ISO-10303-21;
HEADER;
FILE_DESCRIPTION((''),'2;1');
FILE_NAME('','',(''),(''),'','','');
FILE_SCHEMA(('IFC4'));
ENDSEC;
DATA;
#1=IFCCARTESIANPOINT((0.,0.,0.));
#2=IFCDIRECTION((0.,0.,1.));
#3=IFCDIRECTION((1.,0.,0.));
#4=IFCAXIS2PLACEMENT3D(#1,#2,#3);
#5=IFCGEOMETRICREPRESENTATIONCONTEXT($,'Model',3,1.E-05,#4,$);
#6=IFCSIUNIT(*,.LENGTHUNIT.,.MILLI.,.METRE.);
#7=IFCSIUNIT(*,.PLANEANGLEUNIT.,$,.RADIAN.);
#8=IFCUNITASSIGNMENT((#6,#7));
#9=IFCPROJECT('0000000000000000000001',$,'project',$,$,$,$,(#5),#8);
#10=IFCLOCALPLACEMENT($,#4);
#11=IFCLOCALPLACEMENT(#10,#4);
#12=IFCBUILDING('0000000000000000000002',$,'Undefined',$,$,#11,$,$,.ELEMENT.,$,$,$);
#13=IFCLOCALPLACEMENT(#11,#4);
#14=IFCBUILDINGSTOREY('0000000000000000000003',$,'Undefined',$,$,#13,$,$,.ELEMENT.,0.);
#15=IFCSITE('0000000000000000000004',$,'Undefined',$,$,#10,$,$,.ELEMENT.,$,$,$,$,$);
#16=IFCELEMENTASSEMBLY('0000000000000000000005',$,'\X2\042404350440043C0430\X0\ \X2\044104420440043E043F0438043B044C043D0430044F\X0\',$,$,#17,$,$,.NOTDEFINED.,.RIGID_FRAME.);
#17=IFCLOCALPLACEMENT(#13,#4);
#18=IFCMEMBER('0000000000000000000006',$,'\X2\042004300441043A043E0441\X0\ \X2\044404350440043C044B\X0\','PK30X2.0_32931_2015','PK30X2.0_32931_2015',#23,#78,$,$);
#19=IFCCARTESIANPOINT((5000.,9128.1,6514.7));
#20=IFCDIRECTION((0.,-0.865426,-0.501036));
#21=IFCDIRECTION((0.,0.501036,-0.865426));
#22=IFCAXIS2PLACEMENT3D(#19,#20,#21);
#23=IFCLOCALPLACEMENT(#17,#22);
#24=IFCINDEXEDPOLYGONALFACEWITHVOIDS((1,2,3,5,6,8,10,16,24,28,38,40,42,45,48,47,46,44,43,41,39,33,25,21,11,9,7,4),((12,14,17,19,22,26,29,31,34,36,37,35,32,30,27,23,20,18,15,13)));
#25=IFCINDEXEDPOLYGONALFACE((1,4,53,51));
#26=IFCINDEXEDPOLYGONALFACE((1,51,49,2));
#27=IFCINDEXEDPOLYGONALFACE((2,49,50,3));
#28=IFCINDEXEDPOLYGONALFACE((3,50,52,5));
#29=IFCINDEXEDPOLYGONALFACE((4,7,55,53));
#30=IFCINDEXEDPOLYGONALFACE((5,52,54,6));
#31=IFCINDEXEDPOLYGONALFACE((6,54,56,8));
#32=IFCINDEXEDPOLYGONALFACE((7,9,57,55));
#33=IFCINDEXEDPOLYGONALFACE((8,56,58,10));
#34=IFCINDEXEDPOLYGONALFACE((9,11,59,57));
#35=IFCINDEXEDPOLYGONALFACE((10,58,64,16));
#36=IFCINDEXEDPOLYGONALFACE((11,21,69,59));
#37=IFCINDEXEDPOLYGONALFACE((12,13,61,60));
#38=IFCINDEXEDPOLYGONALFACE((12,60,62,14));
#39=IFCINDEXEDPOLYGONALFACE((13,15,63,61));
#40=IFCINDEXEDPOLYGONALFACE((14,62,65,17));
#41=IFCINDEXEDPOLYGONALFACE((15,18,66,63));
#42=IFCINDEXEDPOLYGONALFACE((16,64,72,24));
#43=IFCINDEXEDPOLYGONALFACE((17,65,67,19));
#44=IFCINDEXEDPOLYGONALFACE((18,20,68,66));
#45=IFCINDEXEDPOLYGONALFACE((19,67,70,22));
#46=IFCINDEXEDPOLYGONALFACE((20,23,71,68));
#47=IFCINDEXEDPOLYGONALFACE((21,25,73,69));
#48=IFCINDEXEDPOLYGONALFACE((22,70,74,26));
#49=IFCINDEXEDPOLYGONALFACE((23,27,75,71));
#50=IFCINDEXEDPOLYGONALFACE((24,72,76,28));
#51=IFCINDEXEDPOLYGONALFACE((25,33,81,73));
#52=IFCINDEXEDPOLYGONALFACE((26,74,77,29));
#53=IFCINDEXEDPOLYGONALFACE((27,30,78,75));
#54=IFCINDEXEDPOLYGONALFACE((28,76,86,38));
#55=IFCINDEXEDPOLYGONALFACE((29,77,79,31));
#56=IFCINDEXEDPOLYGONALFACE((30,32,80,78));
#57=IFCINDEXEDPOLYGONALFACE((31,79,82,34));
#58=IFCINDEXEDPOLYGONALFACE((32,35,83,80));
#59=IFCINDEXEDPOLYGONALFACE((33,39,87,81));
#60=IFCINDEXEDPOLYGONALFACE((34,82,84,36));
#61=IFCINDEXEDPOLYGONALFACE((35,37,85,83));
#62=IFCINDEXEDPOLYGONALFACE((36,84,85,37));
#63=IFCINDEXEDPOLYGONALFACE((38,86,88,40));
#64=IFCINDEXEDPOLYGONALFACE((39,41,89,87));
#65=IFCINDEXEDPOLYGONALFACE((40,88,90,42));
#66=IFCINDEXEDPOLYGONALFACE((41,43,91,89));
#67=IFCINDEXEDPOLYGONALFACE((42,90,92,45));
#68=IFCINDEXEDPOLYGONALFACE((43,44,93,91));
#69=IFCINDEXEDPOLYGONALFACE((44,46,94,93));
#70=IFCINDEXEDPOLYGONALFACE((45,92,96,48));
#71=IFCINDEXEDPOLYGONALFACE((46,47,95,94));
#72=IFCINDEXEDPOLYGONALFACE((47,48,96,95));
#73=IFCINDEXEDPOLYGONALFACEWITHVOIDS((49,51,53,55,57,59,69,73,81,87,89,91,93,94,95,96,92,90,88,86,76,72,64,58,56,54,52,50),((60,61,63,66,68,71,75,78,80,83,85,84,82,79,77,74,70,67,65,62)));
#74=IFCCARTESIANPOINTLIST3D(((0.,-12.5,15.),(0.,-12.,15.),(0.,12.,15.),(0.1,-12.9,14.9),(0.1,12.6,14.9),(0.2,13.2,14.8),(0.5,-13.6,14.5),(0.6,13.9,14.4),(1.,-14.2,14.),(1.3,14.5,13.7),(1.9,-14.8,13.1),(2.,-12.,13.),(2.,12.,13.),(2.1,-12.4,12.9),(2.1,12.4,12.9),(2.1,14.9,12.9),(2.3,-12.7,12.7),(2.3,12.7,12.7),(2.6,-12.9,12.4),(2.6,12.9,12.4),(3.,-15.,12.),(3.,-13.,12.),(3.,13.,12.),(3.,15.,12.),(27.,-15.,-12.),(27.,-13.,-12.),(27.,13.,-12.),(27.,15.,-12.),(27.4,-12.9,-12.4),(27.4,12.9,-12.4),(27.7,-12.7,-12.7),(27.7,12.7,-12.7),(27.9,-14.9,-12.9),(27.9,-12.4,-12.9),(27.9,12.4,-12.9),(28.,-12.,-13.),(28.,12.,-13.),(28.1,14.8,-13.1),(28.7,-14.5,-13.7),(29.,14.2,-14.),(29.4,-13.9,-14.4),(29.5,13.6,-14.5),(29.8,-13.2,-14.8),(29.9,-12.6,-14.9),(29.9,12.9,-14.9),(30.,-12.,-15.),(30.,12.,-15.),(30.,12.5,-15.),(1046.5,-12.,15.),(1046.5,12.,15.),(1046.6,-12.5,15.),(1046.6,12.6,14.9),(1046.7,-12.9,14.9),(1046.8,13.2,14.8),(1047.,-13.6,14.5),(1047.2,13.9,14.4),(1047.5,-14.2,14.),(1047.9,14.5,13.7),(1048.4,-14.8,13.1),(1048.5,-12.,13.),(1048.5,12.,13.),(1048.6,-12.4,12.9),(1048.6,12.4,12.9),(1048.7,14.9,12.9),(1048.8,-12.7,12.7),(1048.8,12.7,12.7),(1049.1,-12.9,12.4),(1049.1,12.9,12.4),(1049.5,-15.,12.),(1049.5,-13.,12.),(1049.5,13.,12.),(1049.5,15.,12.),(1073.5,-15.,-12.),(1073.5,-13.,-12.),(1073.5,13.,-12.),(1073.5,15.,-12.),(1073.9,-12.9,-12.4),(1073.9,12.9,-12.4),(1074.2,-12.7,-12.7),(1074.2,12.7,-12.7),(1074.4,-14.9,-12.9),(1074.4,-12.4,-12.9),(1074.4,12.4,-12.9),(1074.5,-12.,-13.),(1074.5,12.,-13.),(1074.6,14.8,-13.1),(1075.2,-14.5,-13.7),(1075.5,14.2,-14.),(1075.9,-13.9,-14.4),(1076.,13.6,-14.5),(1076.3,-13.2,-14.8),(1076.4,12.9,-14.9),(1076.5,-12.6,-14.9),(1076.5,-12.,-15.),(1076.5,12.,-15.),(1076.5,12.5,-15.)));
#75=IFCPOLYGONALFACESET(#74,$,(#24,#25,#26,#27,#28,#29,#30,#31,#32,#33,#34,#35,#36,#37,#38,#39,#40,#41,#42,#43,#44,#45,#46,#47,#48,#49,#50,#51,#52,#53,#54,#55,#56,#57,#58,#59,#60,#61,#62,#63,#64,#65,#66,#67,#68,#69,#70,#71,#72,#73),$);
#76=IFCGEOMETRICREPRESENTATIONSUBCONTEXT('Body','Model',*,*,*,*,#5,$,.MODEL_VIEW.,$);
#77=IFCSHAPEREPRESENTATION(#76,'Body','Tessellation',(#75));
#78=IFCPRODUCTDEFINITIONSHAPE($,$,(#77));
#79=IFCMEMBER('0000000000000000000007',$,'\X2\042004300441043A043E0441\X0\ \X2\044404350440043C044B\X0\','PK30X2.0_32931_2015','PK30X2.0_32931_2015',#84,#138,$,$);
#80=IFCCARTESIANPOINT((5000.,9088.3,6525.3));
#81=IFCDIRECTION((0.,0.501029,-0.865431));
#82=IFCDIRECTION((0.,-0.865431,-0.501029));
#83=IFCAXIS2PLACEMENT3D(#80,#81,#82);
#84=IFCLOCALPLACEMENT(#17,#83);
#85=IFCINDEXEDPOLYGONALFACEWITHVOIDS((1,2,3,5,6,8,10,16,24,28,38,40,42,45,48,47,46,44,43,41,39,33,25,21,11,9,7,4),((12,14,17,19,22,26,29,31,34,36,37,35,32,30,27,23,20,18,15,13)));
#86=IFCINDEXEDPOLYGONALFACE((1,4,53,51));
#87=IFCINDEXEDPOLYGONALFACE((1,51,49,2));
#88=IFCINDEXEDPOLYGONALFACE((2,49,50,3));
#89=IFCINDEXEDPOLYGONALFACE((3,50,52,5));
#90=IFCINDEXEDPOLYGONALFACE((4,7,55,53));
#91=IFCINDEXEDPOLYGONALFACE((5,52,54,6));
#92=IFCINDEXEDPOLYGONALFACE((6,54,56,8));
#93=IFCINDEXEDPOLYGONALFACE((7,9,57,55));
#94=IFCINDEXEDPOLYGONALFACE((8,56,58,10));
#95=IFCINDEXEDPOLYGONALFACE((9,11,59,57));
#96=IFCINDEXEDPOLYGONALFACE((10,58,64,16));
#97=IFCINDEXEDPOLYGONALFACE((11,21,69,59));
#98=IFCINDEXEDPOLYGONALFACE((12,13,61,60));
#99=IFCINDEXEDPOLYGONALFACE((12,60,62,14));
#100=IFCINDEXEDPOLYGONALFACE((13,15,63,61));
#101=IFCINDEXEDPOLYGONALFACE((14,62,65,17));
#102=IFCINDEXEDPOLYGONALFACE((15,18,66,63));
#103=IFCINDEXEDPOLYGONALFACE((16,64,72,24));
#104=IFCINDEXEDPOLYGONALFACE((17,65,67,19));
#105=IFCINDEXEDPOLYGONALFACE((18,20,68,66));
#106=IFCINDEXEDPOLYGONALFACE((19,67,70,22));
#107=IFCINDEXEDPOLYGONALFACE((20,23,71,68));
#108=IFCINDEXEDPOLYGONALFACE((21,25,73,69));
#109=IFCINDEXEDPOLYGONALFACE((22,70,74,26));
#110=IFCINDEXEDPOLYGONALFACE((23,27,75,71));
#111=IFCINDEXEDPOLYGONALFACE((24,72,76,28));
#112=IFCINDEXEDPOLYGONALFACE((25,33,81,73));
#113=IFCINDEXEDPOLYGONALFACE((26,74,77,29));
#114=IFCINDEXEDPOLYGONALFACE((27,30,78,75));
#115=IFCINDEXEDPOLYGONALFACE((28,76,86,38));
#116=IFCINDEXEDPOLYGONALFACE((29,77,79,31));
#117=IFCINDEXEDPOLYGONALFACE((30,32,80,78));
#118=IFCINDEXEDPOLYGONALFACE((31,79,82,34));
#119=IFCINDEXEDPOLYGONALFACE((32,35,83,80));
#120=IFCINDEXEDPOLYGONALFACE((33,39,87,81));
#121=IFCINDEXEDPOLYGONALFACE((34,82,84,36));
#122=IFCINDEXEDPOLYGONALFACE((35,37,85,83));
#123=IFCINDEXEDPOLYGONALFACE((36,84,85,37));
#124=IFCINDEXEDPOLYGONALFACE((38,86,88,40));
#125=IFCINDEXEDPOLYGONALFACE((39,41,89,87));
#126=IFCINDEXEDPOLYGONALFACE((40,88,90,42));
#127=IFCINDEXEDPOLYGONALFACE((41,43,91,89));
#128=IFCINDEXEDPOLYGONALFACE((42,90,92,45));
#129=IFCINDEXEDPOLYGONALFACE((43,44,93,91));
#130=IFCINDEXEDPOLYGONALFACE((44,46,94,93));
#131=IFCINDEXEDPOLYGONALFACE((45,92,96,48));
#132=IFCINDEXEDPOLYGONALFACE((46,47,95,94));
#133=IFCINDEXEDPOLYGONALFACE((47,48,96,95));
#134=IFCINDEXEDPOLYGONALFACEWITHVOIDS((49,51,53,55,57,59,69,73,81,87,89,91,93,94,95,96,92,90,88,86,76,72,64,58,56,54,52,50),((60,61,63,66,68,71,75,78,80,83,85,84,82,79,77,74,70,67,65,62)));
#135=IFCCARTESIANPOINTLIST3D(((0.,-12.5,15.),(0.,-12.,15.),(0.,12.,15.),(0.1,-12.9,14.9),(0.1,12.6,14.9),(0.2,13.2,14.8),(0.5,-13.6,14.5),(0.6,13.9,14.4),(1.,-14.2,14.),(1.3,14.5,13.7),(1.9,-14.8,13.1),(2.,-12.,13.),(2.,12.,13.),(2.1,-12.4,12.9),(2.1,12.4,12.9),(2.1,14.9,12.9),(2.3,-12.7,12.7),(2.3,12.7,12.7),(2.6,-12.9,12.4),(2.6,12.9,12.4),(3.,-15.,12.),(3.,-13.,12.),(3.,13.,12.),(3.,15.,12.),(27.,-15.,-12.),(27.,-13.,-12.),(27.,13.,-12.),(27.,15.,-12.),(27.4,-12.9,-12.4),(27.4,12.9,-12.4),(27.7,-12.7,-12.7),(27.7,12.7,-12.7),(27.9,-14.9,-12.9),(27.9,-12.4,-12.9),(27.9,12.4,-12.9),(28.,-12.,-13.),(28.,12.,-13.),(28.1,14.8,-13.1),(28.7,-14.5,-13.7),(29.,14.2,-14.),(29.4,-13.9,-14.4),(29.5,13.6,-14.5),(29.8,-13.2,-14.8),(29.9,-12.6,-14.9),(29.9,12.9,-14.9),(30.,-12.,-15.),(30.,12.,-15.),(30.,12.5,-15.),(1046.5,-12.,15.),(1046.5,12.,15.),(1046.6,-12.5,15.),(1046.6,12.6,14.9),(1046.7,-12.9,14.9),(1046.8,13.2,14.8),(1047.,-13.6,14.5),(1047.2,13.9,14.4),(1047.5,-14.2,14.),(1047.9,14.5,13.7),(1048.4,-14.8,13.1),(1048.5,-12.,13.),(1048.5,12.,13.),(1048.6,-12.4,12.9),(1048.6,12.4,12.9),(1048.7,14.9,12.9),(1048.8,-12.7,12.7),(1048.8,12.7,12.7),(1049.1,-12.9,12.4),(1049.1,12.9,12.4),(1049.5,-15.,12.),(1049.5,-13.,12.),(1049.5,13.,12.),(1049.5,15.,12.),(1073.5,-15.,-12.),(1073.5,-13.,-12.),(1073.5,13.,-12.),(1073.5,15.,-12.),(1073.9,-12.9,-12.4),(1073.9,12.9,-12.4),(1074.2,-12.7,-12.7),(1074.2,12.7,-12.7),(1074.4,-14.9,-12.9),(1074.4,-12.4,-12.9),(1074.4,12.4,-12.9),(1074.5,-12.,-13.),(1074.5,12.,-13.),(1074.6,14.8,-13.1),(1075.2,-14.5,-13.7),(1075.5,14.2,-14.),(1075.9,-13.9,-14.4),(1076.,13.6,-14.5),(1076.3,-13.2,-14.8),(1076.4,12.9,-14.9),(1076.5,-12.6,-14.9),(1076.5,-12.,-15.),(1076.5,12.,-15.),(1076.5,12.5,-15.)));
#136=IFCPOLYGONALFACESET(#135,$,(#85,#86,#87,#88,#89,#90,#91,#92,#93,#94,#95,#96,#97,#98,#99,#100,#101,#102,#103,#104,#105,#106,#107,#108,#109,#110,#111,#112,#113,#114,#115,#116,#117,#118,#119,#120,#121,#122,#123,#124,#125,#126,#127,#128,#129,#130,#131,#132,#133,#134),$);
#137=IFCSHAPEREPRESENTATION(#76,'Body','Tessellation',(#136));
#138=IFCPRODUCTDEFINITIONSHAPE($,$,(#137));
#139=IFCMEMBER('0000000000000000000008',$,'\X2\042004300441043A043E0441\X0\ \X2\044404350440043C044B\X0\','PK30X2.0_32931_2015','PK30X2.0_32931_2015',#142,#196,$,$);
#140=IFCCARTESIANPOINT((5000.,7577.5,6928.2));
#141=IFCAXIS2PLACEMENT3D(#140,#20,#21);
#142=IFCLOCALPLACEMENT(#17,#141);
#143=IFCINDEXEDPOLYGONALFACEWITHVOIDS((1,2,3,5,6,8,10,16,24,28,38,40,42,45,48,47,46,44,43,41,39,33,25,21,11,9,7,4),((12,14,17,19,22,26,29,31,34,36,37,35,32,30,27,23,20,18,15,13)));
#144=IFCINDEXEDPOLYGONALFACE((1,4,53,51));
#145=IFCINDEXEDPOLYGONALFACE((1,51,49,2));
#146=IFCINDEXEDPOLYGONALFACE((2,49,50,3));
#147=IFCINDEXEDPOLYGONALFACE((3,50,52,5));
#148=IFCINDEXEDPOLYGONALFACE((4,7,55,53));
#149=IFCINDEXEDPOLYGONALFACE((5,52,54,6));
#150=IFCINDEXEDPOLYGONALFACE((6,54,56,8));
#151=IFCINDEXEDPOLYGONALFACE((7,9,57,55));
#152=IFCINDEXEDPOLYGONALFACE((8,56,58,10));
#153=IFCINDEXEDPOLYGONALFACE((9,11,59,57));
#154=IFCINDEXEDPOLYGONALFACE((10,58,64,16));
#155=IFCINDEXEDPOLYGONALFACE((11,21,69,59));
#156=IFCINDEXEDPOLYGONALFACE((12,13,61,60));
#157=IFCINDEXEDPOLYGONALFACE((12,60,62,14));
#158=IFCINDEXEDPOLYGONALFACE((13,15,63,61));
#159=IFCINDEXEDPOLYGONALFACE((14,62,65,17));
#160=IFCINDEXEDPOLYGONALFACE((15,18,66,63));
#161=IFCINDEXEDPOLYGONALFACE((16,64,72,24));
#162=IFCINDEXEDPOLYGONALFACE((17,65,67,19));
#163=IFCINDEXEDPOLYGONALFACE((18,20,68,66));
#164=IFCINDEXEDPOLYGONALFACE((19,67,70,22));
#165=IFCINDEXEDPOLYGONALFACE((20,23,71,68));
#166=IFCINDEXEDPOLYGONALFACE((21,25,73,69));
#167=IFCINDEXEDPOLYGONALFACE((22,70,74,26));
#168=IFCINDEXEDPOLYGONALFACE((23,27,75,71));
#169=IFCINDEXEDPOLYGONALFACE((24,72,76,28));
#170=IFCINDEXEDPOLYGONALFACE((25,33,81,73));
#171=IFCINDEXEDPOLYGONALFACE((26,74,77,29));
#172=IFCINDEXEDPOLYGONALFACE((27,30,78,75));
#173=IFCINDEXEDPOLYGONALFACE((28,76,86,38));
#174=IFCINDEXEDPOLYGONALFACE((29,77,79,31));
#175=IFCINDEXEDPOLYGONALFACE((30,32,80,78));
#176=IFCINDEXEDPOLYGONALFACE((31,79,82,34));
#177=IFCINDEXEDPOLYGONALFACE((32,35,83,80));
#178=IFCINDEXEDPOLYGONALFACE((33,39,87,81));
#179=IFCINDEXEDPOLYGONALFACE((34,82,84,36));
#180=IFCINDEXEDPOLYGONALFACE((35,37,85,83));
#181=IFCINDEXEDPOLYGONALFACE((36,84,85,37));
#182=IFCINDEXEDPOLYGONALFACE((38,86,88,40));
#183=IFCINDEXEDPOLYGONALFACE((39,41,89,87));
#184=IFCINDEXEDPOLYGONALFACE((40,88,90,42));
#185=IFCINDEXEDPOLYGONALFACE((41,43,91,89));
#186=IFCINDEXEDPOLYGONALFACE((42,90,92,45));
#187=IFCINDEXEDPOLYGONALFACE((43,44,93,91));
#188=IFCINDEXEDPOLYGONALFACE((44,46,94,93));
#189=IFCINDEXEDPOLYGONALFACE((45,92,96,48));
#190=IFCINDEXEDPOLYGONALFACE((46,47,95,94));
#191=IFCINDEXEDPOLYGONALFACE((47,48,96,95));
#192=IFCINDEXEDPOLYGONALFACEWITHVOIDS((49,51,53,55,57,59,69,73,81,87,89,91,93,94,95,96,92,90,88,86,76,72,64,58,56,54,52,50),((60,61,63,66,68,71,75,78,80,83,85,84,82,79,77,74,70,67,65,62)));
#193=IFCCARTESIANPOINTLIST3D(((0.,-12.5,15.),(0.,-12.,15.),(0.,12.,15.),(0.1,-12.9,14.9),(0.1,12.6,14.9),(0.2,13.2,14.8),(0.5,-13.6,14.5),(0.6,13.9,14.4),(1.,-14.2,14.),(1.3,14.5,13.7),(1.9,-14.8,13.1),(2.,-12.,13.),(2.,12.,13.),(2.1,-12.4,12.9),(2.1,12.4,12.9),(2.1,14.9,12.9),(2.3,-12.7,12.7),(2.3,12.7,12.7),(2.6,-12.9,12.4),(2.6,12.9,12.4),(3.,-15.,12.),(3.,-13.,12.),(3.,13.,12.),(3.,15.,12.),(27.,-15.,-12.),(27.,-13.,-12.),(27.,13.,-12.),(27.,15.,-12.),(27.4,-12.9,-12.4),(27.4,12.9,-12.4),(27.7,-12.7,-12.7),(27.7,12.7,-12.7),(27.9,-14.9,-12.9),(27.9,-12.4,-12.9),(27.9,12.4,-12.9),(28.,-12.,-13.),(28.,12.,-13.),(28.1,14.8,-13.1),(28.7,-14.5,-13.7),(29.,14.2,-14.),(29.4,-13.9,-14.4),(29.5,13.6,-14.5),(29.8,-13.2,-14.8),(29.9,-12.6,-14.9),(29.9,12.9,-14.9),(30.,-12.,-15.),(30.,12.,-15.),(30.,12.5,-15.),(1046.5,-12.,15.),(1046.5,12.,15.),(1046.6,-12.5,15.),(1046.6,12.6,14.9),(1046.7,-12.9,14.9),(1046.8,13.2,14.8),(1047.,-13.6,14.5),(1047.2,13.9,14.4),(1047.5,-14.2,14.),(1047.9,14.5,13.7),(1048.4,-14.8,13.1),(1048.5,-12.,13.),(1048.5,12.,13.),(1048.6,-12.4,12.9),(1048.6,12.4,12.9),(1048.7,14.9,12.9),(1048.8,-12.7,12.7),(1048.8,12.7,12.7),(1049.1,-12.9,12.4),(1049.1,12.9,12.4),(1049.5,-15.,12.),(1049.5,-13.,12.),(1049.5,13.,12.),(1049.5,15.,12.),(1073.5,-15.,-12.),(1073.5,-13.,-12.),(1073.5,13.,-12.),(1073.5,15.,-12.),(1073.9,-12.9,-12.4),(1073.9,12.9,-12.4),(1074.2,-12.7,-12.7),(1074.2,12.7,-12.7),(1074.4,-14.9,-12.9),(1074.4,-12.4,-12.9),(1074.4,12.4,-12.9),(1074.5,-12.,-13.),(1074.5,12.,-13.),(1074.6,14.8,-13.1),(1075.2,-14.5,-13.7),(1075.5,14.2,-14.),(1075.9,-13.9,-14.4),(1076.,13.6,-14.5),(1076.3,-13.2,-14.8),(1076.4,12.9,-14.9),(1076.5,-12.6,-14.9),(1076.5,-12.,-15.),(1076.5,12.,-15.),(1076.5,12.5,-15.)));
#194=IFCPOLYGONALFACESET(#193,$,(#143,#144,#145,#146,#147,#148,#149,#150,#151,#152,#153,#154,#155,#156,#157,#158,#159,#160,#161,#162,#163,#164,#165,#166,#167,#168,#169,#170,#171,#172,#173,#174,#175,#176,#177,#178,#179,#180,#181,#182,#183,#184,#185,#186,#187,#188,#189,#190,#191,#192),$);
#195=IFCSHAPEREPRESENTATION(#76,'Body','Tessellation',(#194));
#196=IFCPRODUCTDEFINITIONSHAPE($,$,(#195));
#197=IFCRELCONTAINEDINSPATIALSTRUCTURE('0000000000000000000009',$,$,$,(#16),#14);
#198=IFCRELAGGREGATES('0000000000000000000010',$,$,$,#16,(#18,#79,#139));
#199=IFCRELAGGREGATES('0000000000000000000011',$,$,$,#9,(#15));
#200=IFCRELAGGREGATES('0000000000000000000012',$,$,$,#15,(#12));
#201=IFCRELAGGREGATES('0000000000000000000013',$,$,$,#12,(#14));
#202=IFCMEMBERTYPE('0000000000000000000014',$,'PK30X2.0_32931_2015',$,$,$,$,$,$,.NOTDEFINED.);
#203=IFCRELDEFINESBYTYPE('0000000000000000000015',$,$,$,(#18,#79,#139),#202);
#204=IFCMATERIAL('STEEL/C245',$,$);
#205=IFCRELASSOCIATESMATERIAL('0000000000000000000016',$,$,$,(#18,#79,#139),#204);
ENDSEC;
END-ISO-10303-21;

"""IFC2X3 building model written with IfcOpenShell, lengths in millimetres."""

from ifc_helpers import new_model, si_unit, frame, origin_with_axes, origin_2d_with_axis, place, context, subcontext, project, spatial, hollow_rectangle, extrude, clip, halfspace, material, type_object, element, aggregate, save


model = new_model("IFC2X3")

# Units and contexts
model_context = context("Model", 3, precision=1e-05, world=origin_with_axes())
body_context = subcontext(model_context, "Body", "Model", "MODEL_VIEW")
ifc_project = project(units=[si_unit("LENGTHUNIT", "METRE", prefix="MILLI"), si_unit("PLANEANGLEUNIT", "RADIAN")], contexts=[model_context])

# Site, building, storey
site_placement = place(None, origin_with_axes())
site = spatial("IfcSite", under=ifc_project, at=site_placement, Name="Undefined", CompositionType="ELEMENT")
building_placement = place(site_placement, origin_with_axes())
building = spatial("IfcBuilding", under=site, at=building_placement, Name="Undefined", CompositionType="ELEMENT")
storey_placement = place(building_placement, origin_with_axes())
storey = spatial("IfcBuildingStorey", under=building, at=storey_placement, Name="Undefined", CompositionType="ELEMENT", Elevation=0.0)

# Element assembly
ifc_material_1 = material(Name="STEEL/C245")
assembly_1_placement = place(storey_placement, origin_with_axes())
assembly_1 = element("IfcElementAssembly", 1, at=assembly_1_placement, inside=storey, Name="Ферма стропильная", AssemblyPlace="NOTDEFINED", PredefinedType="RIGID_FRAME")

# Members
member_type = type_object("IfcMemberType", Name="PK30X2.0_32931_2015", PredefinedType="NOTDEFINED")
member_1_placement = place(assembly_1_placement, frame((5000.0, 9128.1, 6514.7), z_axis=(0.0, -0.865426, -0.501036), x_axis=(0.0, 0.501036, -0.865426)))
member_1 = element("IfcMember", 2, at=member_1_placement, type_object=member_type, material=ifc_material_1, Name="Раскос фермы", Description="PK30X2.0_32931_2015", ObjectType="PK30X2.0_32931_2015", context=body_context, shape_type="Clipping", body=[
    clip(clip(extrude(hollow_rectangle(XDim=30.0, YDim=30.0, WallThickness=2.0, InnerFilletRadius=1.0, OuterFilletRadius=3.0, at=origin_2d_with_axis()), frame((1091.8, 0.0, 0.0), z_axis=(-1.0, 0.0, 0.0), x_axis=(0.0, -1.0, 0.0)), (0.0, 0.0, 1.0), 1107.1), halfspace(frame((1060.0, 0.0, 1.5), z_axis=(-0.707107, 0.0, -0.707107), x_axis=(0.707107, 0.0, -0.707107)), True)), halfspace(frame((34.5, 0.0, -19.5), z_axis=(-0.707107, 0.0, -0.707107), x_axis=(0.707107, 0.0, -0.707107)), False)),
])
member_2_placement = place(assembly_1_placement, frame((5000.0, 9088.3, 6525.3), z_axis=(0.0, 0.501029, -0.865431), x_axis=(0.0, -0.865431, -0.501029)))
member_2 = element("IfcMember", 3, at=member_2_placement, type_object=member_type, material=ifc_material_1, Name="Раскос фермы", Description="PK30X2.0_32931_2015", ObjectType="PK30X2.0_32931_2015", context=body_context, shape_type="Clipping", body=[
    clip(clip(extrude(hollow_rectangle(XDim=30.0, YDim=30.0, WallThickness=2.0, InnerFilletRadius=1.0, OuterFilletRadius=3.0, at=origin_2d_with_axis()), frame((1102.9, 0.0, 0.0), z_axis=(-1.0, 0.0, 0.0), x_axis=(0.0, -1.0, 0.0)), (0.0, 0.0, 1.0), 1129.2), halfspace(frame((1060.0, 0.0, 1.5), z_axis=(-0.707107, 0.0, -0.707107), x_axis=(0.707107, 0.0, -0.707107)), True)), halfspace(frame((34.5, 0.0, -19.5), z_axis=(-0.707107, 0.0, -0.707107), x_axis=(0.707107, 0.0, -0.707107)), False)),
])
member_3_placement = place(assembly_1_placement, frame((5000.0, 7577.5, 6928.2), z_axis=(0.0, -0.865426, -0.501036), x_axis=(0.0, 0.501036, -0.865426)))
member_3 = element("IfcMember", 4, at=member_3_placement, type_object=member_type, material=ifc_material_1, Name="Раскос фермы", Description="PK30X2.0_32931_2015", ObjectType="PK30X2.0_32931_2015", context=body_context, shape_type="Clipping", body=[
    clip(clip(extrude(hollow_rectangle(XDim=30.0, YDim=30.0, WallThickness=2.0, InnerFilletRadius=1.0, OuterFilletRadius=3.0, at=origin_2d_with_axis()), frame((1091.8, 0.0, 0.0), z_axis=(-1.0, 0.0, 0.0), x_axis=(0.0, -1.0, 0.0)), (0.0, 0.0, 1.0), 1107.1), halfspace(frame((1060.0, 0.0, 1.5), z_axis=(-0.707107, 0.0, -0.707107), x_axis=(0.707107, 0.0, -0.707107)), True)), halfspace(frame((34.5, 0.0, -19.5), z_axis=(-0.707107, 0.0, -0.707107), x_axis=(0.707107, 0.0, -0.707107)), False)),
])
aggregate(assembly_1, [member_1, member_2, member_3])

save(model, "model.ifc")
